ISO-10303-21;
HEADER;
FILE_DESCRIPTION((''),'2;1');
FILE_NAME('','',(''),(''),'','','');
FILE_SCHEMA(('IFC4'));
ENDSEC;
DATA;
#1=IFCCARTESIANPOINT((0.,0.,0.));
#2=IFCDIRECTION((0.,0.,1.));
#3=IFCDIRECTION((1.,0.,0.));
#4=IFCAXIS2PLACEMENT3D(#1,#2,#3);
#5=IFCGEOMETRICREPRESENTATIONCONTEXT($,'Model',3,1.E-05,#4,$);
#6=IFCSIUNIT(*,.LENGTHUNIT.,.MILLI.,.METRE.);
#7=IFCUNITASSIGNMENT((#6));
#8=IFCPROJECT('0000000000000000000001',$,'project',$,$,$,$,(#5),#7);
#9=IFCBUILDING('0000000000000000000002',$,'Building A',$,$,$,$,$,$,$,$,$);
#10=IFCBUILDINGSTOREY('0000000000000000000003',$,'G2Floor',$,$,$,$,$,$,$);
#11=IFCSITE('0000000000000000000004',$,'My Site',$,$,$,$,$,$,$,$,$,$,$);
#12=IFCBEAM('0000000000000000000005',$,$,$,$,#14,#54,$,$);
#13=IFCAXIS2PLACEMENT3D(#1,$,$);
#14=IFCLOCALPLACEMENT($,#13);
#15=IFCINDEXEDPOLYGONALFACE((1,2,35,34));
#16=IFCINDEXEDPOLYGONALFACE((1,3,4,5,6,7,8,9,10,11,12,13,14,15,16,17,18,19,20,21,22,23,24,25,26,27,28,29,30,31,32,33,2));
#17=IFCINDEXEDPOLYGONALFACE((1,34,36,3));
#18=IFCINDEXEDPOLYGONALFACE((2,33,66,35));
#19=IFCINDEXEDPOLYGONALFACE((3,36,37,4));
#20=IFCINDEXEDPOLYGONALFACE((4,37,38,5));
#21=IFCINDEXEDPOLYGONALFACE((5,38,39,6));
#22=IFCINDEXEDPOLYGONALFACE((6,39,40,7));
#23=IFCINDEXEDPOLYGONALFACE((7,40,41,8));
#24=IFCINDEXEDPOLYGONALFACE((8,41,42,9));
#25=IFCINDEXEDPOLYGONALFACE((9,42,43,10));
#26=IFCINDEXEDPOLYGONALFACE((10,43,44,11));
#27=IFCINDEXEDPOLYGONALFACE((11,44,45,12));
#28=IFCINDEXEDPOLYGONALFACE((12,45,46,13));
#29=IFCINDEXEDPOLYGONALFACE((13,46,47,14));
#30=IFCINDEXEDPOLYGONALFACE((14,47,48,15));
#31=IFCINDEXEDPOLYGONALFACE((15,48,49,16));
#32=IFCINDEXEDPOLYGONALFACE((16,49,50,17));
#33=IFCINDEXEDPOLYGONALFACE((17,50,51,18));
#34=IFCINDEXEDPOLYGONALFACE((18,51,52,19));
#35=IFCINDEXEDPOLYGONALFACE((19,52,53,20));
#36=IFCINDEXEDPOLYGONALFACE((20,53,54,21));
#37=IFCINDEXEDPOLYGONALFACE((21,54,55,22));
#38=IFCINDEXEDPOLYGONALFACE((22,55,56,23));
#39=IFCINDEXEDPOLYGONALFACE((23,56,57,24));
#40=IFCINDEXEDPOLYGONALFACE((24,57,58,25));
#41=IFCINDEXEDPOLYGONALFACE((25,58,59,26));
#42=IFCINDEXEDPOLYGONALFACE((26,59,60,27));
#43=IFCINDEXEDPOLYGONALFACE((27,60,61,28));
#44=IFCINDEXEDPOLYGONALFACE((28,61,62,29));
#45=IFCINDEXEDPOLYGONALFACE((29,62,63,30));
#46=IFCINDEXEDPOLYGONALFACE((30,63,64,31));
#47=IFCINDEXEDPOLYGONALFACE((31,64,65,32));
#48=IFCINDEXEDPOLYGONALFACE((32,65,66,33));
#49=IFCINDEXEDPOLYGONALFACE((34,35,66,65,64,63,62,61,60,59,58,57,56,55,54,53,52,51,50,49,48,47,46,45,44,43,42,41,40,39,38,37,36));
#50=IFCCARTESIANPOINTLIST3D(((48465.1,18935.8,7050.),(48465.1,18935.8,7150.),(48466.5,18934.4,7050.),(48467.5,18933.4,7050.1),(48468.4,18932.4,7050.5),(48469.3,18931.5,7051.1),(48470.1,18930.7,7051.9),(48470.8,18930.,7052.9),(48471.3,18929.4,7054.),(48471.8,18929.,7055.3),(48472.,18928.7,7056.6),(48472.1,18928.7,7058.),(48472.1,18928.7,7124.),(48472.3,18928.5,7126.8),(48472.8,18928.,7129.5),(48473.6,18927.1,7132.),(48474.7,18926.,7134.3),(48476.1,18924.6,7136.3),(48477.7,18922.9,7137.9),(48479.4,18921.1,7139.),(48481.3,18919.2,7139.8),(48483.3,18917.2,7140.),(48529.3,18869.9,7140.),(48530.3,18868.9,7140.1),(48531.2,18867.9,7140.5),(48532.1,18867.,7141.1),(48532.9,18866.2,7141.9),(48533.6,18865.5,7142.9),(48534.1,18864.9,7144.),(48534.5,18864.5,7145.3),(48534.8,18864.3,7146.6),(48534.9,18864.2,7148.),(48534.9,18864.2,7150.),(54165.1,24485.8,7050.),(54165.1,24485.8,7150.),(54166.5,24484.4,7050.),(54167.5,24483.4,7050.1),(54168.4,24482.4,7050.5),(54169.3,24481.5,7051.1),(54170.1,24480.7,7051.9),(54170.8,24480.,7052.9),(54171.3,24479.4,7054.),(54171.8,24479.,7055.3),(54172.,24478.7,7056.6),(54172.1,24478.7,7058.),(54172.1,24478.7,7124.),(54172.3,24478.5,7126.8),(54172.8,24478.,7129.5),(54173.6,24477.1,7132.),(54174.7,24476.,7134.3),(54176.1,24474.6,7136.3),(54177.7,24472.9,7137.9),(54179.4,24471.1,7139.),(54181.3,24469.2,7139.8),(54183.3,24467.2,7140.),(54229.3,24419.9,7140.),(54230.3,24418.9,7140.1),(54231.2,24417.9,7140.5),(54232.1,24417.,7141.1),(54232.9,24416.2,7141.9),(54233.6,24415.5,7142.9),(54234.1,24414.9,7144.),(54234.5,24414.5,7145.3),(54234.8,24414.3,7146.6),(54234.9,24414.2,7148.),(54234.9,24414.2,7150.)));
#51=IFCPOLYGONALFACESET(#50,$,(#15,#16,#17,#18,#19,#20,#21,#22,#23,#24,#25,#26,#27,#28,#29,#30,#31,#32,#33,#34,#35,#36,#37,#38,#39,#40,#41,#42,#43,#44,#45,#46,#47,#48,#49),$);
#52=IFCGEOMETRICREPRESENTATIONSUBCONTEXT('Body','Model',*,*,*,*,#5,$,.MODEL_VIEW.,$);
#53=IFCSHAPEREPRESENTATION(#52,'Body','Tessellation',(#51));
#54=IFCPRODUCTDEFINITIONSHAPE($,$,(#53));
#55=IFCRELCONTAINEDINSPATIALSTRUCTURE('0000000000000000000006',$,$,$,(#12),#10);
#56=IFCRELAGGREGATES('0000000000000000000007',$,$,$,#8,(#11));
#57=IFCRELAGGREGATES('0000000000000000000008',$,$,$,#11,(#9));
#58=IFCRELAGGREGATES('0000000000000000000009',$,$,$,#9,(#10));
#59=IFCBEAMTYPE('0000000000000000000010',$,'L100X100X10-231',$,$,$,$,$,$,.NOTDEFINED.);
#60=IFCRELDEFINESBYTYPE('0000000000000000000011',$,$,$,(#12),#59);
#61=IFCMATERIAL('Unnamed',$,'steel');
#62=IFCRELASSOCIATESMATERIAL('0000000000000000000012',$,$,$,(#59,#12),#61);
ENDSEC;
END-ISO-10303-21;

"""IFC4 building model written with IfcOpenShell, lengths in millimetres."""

from ifc_helpers import new_model, si_unit, frame, origin_with_axes, place, context, subcontext, project, spatial, polyline, outline, extrude, material, material_profile, profile_set, profile_usage, type_object, element, save


model = new_model("IFC4")

# Units and contexts
model_context = context("Model", 3, precision=1e-05, world=origin_with_axes())
body_context = subcontext(model_context, "Body", "Model", "MODEL_VIEW")
ifc_project = project(units=[si_unit("LENGTHUNIT", "METRE", prefix="MILLI")], contexts=[model_context])

# Site, building, storey
site = spatial("IfcSite", under=ifc_project, Name="My Site")
building = spatial("IfcBuilding", under=site, Name="Building A")
storey = spatial("IfcBuildingStorey", under=building, Name="G2Floor")

# Beam
ifc_material_1 = material(Name="Unnamed", Category="steel")
ifc_material_profile_1 = material_profile(ifc_material_1, outline(polyline([(-50.0, -50.0), (50.0, -50.0), (50.0, -50.0), (50.0, -48.0), (50.0, -48.0), (49.9, -46.6), (49.9, -46.6), (49.5, -45.3), (49.5, -45.3), (48.9, -44.0), (48.9, -44.0), (48.1, -42.9), (48.1, -42.9), (47.1, -41.9), (47.1, -41.9), (46.0, -41.1), (46.0, -41.1), (44.7, -40.5), (44.7, -40.5), (43.4, -40.1), (43.4, -40.1), (42.0, -40.0), (42.0, -40.0), (-24.0, -40.0), (-24.0, -40.0), (-26.8, -39.8), (-26.8, -39.8), (-29.5, -39.0), (-29.5, -39.0), (-32.0, -37.9), (-32.0, -37.9), (-34.3, -36.3), (-34.3, -36.3), (-36.3, -34.3), (-36.3, -34.3), (-37.9, -32.0), (-37.9, -32.0), (-39.0, -29.5), (-39.0, -29.5), (-39.8, -26.8), (-39.8, -26.8), (-40.0, -24.0), (-40.0, -24.0), (-40.0, 42.0), (-40.0, 42.0), (-40.1, 43.4), (-40.1, 43.4), (-40.5, 44.7), (-40.5, 44.7), (-41.1, 46.0), (-41.1, 46.0), (-41.9, 47.1), (-41.9, 47.1), (-42.9, 48.1), (-42.9, 48.1), (-44.0, 48.9), (-44.0, 48.9), (-45.3, 49.5), (-45.3, 49.5), (-46.6, 49.9), (-46.6, 49.9), (-48.0, 50.0), (-48.0, 50.0), (-50.0, 50.0), (-50.0, 50.0), (-50.0, -50.0)])))
ifc_profile_set_1 = profile_set([ifc_material_profile_1], Name="L100X100X10-231")
ifc_profile_usage_1 = profile_usage(ifc_profile_set_1)
beam_type_1 = type_object("IfcBeamType", Name="L100X100X10-231", PredefinedType="NOTDEFINED", material=ifc_profile_set_1)
beam_1_placement = place(None, frame((48500.0, 18900.0, 7100.0), z_axis=(0.716471, 0.697617, 0.0), x_axis=(0.697617, -0.716471, 0.0)))
element("IfcBeam", 1, at=beam_1_placement, inside=storey, type_object=beam_type_1, material=ifc_profile_usage_1, context=body_context, shape_type="SweptSolid", body=[
    extrude(outline(polyline([(-50.0, -50.0), (50.0, -50.0), (50.0, -50.0), (50.0, -48.0), (50.0, -48.0), (49.9, -46.6), (49.9, -46.6), (49.5, -45.3), (49.5, -45.3), (48.9, -44.0), (48.9, -44.0), (48.1, -42.9), (48.1, -42.9), (47.1, -41.9), (47.1, -41.9), (46.0, -41.1), (46.0, -41.1), (44.7, -40.5), (44.7, -40.5), (43.4, -40.1), (43.4, -40.1), (42.0, -40.0), (42.0, -40.0), (-24.0, -40.0), (-24.0, -40.0), (-26.8, -39.8), (-26.8, -39.8), (-29.5, -39.0), (-29.5, -39.0), (-32.0, -37.9), (-32.0, -37.9), (-34.3, -36.3), (-34.3, -36.3), (-36.3, -34.3), (-36.3, -34.3), (-37.9, -32.0), (-37.9, -32.0), (-39.0, -29.5), (-39.0, -29.5), (-39.8, -26.8), (-39.8, -26.8), (-40.0, -24.0), (-40.0, -24.0), (-40.0, 42.0), (-40.0, 42.0), (-40.1, 43.4), (-40.1, 43.4), (-40.5, 44.7), (-40.5, 44.7), (-41.1, 46.0), (-41.1, 46.0), (-41.9, 47.1), (-41.9, 47.1), (-42.9, 48.1), (-42.9, 48.1), (-44.0, 48.9), (-44.0, 48.9), (-45.3, 49.5), (-45.3, 49.5), (-46.6, 49.9), (-46.6, 49.9), (-48.0, 50.0), (-48.0, 50.0), (-50.0, 50.0), (-50.0, 50.0), (-50.0, -50.0)])), origin_with_axes(), (0.0, 0.0, 1.0), 7955.7),
])

save(model, "model.ifc")
